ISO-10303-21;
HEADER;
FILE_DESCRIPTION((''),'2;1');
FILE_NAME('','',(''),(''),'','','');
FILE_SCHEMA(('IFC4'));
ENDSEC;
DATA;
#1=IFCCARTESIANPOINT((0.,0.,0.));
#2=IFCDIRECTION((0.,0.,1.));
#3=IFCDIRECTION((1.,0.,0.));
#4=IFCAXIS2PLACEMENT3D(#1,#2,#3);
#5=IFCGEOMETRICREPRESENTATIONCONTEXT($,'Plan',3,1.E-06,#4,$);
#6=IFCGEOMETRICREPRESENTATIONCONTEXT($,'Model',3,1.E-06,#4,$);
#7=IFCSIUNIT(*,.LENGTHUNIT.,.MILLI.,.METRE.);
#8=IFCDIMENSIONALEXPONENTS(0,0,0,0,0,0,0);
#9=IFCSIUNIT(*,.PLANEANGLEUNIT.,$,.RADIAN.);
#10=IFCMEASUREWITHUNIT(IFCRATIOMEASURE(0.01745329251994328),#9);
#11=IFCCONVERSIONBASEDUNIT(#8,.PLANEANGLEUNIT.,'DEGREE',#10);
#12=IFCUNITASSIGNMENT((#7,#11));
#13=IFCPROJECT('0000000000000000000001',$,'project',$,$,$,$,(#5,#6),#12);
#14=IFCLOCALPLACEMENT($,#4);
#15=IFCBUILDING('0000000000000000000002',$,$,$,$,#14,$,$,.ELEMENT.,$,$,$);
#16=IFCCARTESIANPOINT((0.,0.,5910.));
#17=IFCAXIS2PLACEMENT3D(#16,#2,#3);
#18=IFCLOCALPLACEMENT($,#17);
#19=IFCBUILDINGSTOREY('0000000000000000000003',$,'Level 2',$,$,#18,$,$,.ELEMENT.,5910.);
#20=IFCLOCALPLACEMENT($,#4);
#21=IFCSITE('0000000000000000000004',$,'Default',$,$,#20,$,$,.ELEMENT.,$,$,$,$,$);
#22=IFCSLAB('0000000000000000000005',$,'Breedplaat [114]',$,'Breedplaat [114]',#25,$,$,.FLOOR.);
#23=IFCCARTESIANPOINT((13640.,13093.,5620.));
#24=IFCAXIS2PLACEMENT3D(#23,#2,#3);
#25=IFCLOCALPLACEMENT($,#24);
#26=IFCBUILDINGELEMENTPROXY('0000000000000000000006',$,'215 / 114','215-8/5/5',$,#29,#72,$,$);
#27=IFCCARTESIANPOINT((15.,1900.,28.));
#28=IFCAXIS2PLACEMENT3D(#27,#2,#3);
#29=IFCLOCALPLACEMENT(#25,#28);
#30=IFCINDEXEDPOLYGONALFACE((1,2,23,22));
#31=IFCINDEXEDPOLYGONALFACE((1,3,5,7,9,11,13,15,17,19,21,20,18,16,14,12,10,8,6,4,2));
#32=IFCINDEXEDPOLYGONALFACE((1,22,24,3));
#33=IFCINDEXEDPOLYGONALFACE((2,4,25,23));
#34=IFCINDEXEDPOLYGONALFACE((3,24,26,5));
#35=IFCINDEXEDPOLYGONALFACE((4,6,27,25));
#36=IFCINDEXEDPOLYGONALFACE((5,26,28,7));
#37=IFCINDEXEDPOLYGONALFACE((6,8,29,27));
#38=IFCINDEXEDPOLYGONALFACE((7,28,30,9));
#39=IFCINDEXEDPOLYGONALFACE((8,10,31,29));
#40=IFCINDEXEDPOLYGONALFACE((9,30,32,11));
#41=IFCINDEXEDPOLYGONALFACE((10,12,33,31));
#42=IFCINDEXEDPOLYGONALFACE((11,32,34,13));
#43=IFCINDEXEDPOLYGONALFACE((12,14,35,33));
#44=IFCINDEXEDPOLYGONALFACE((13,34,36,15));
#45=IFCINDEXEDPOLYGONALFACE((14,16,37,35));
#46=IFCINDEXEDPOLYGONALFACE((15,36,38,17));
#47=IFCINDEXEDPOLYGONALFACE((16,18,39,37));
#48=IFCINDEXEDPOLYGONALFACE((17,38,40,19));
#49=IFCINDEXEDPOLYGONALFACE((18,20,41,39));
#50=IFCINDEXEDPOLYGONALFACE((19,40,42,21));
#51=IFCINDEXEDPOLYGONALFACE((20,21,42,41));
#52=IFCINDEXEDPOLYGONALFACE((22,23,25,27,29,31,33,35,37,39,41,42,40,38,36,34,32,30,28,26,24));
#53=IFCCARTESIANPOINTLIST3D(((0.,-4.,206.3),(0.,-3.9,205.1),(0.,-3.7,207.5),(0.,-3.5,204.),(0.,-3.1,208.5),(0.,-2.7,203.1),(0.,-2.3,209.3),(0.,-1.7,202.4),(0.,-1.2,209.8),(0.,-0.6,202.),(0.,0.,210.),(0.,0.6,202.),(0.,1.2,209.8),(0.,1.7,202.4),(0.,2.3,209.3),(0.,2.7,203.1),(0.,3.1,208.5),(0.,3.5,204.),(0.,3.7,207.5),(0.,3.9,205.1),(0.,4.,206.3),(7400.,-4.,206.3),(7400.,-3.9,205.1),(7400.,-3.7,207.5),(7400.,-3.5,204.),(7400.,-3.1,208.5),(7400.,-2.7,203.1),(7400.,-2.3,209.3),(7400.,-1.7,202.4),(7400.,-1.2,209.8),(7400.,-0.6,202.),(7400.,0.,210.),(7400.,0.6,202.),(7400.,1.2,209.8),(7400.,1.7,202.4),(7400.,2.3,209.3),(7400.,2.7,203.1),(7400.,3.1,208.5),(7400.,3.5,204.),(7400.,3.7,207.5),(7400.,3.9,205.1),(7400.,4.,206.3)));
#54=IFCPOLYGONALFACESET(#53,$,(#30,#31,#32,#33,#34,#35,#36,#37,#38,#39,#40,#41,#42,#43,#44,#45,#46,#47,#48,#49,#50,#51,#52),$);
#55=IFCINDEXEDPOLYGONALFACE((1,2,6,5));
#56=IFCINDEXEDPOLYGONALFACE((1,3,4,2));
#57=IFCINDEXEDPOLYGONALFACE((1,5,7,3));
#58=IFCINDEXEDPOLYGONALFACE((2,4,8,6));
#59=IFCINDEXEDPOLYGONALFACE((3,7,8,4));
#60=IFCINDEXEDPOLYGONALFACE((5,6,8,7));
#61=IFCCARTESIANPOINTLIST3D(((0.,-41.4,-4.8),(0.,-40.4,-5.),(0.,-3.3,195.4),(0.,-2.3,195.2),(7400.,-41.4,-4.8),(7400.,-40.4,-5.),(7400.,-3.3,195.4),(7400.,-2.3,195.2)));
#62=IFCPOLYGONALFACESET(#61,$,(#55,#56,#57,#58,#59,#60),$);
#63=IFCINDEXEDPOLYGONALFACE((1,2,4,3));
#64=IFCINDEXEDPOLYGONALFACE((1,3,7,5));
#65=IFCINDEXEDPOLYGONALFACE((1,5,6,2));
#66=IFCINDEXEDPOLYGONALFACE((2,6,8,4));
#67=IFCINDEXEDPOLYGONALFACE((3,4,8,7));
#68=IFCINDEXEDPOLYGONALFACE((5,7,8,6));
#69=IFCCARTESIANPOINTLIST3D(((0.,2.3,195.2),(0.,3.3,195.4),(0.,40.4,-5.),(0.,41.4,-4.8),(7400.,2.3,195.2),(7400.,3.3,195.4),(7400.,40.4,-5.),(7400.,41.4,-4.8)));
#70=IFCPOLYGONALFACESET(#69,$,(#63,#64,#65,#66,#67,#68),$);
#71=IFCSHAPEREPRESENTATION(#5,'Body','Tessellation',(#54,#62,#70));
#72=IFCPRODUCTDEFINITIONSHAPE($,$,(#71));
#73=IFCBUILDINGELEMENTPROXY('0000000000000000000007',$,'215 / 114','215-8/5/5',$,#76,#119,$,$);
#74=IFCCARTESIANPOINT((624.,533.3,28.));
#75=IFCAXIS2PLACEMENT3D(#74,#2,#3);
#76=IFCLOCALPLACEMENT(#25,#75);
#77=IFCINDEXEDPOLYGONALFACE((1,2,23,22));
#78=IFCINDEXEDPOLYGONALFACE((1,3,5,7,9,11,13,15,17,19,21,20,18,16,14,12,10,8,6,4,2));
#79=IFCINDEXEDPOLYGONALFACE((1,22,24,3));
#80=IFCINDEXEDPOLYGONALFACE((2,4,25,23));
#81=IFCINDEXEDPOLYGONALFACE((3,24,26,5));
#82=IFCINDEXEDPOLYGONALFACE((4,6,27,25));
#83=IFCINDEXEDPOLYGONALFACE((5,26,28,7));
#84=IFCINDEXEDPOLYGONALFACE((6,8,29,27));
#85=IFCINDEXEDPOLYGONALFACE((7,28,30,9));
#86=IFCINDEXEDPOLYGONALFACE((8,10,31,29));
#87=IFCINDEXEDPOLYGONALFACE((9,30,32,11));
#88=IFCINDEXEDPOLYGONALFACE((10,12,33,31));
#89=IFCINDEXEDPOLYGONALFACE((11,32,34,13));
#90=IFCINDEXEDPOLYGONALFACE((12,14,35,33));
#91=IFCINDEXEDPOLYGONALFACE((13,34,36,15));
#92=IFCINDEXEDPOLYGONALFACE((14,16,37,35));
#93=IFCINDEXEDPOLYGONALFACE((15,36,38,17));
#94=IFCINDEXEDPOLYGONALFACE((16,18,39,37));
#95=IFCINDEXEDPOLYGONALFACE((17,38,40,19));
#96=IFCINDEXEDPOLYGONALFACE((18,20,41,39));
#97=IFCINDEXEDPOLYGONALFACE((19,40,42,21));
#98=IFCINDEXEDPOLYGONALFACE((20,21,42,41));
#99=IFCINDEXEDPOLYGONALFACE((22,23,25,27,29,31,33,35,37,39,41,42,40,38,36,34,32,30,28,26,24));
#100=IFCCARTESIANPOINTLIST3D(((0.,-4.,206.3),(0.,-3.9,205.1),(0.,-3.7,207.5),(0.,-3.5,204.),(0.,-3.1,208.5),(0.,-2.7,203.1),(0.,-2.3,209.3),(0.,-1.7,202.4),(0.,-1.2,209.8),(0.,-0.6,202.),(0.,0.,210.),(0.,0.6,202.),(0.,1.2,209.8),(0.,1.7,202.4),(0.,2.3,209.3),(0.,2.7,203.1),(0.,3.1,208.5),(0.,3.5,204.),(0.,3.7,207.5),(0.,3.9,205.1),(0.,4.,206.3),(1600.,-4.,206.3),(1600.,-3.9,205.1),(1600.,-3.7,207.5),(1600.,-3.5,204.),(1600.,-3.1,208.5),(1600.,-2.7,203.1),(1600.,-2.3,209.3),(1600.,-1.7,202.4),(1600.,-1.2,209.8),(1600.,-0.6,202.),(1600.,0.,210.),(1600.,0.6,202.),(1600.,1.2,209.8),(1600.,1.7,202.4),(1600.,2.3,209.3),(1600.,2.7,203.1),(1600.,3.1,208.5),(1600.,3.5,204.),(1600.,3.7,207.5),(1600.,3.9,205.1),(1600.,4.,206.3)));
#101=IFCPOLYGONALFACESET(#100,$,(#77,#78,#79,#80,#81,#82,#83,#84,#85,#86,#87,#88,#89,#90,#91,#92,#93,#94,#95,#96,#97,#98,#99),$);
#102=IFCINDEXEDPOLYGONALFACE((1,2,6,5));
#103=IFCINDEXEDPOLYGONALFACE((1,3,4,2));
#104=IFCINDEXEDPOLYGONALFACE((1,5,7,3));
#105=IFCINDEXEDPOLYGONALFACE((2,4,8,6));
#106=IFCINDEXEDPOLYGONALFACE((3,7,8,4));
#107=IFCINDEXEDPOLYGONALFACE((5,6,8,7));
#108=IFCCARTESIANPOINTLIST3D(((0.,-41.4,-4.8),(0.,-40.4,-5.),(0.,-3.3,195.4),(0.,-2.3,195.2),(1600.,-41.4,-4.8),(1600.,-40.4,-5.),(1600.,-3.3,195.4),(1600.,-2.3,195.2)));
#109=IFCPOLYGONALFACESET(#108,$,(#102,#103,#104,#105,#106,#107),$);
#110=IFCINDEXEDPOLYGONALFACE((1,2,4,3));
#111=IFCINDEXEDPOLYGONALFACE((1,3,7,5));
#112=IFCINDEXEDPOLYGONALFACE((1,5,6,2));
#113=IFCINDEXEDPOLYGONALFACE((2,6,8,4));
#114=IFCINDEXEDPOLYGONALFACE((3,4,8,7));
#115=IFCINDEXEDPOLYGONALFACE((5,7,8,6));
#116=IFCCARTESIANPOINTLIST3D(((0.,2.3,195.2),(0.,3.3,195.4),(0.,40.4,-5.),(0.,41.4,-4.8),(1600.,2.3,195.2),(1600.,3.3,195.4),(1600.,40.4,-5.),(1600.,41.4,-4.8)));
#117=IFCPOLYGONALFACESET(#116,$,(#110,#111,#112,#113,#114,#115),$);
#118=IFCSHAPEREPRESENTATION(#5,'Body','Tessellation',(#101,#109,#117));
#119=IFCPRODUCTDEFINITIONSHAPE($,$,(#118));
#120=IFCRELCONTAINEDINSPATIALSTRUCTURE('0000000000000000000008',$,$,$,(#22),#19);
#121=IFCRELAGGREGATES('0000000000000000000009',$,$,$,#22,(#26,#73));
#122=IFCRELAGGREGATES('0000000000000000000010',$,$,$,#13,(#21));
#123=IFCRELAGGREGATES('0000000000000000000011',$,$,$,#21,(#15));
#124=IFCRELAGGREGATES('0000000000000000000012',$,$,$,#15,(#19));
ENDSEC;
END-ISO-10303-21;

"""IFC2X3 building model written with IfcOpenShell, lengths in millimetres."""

from ifc_helpers import new_model, entity, si_unit, converted_unit, frame, origin_with_axes, origin_2d_with_axis, place, context, project, spatial, rectangle, circle, extrude, element, aggregate, save


model = new_model("IFC2X3")

# Units and contexts
plan_context = context("Plan", 3, precision=1e-06, world=origin_with_axes())
model_context = context("Model", 3, precision=1e-06, world=origin_with_axes())
ifc_project = project(units=[si_unit("LENGTHUNIT", "METRE", prefix="MILLI"), converted_unit("PLANEANGLEUNIT", "DEGREE", entity("IfcRatioMeasure", 0.01745329251994328), si_unit("PLANEANGLEUNIT", "RADIAN"), dimensions=[0, 0, 0, 0, 0, 0, 0])], contexts=[plan_context, model_context])

# Site, building, storey
site_placement = place(None, origin_with_axes())
site = spatial("IfcSite", under=ifc_project, at=site_placement, Name="Default", CompositionType="ELEMENT")
building_placement = place(None, origin_with_axes())
building = spatial("IfcBuilding", under=site, at=building_placement, CompositionType="ELEMENT")
storey_placement = place(None, frame((0.0, 0.0, 5910.0), z_axis=(0.0, 0.0, 1.0), x_axis=(1.0, 0.0, 0.0)))
storey = spatial("IfcBuildingStorey", under=building, at=storey_placement, Name="Level 2", CompositionType="ELEMENT", Elevation=5910.0)

# Slab, building element proxies
slab_1_placement = place(None, frame((13640.0, 13093.0, 5620.0), z_axis=(0.0, 0.0, 1.0), x_axis=(1.0, 0.0, 0.0)))
slab_1 = element("IfcSlab", 1, at=slab_1_placement, inside=storey, Name="Breedplaat [114]", ObjectType="Breedplaat [114]", PredefinedType="FLOOR")
proxy_1_placement = place(slab_1_placement, frame((15.0, 1900.0, 28.0), z_axis=(0.0, 0.0, 1.0), x_axis=(1.0, 0.0, 0.0)))
proxy_1 = element("IfcBuildingElementProxy", 2, at=proxy_1_placement, Name="215 / 114", Description="215-8/5/5", context=plan_context, shape_type="SweptSolid", body=[
    extrude(circle(Radius=4.0, at=origin_2d_with_axis()), frame((0.0, 0.0, 206.0), z_axis=(1.0, 0.0, 0.0), x_axis=(0.0, 0.0, 1.0)), (0.0, 0.0, 1.0), 7400.0),
    extrude(rectangle(XDim=203.8, YDim=1.0, at=origin_2d_with_axis()), frame((0.0, -21.9, 95.2), z_axis=(1.0, 0.0, 0.0), x_axis=(0.0, 0.187112, 0.982339)), (0.0, 0.0, 1.0), 7400.0),
    extrude(rectangle(XDim=203.8, YDim=1.0, at=origin_2d_with_axis()), frame((0.0, 21.9, 95.2), z_axis=(1.0, 0.0, 0.0), x_axis=(0.0, -0.187112, 0.982339)), (0.0, 0.0, 1.0), 7400.0),
])
proxy_2_placement = place(slab_1_placement, frame((624.0, 533.3, 28.0), z_axis=(0.0, 0.0, 1.0), x_axis=(1.0, 0.0, 0.0)))
proxy_2 = element("IfcBuildingElementProxy", 3, at=proxy_2_placement, Name="215 / 114", Description="215-8/5/5", context=plan_context, shape_type="SweptSolid", body=[
    extrude(circle(Radius=4.0, at=origin_2d_with_axis()), frame((0.0, 0.0, 206.0), z_axis=(1.0, 0.0, 0.0), x_axis=(0.0, 0.0, 1.0)), (0.0, 0.0, 1.0), 1600.0),
    extrude(rectangle(XDim=203.8, YDim=1.0, at=origin_2d_with_axis()), frame((0.0, -21.9, 95.2), z_axis=(1.0, 0.0, 0.0), x_axis=(0.0, 0.187112, 0.982339)), (0.0, 0.0, 1.0), 1600.0),
    extrude(rectangle(XDim=203.8, YDim=1.0, at=origin_2d_with_axis()), frame((0.0, 21.9, 95.2), z_axis=(1.0, 0.0, 0.0), x_axis=(0.0, -0.187112, 0.982339)), (0.0, 0.0, 1.0), 1600.0),
])
aggregate(slab_1, [proxy_1, proxy_2])

save(model, "model.ifc")
